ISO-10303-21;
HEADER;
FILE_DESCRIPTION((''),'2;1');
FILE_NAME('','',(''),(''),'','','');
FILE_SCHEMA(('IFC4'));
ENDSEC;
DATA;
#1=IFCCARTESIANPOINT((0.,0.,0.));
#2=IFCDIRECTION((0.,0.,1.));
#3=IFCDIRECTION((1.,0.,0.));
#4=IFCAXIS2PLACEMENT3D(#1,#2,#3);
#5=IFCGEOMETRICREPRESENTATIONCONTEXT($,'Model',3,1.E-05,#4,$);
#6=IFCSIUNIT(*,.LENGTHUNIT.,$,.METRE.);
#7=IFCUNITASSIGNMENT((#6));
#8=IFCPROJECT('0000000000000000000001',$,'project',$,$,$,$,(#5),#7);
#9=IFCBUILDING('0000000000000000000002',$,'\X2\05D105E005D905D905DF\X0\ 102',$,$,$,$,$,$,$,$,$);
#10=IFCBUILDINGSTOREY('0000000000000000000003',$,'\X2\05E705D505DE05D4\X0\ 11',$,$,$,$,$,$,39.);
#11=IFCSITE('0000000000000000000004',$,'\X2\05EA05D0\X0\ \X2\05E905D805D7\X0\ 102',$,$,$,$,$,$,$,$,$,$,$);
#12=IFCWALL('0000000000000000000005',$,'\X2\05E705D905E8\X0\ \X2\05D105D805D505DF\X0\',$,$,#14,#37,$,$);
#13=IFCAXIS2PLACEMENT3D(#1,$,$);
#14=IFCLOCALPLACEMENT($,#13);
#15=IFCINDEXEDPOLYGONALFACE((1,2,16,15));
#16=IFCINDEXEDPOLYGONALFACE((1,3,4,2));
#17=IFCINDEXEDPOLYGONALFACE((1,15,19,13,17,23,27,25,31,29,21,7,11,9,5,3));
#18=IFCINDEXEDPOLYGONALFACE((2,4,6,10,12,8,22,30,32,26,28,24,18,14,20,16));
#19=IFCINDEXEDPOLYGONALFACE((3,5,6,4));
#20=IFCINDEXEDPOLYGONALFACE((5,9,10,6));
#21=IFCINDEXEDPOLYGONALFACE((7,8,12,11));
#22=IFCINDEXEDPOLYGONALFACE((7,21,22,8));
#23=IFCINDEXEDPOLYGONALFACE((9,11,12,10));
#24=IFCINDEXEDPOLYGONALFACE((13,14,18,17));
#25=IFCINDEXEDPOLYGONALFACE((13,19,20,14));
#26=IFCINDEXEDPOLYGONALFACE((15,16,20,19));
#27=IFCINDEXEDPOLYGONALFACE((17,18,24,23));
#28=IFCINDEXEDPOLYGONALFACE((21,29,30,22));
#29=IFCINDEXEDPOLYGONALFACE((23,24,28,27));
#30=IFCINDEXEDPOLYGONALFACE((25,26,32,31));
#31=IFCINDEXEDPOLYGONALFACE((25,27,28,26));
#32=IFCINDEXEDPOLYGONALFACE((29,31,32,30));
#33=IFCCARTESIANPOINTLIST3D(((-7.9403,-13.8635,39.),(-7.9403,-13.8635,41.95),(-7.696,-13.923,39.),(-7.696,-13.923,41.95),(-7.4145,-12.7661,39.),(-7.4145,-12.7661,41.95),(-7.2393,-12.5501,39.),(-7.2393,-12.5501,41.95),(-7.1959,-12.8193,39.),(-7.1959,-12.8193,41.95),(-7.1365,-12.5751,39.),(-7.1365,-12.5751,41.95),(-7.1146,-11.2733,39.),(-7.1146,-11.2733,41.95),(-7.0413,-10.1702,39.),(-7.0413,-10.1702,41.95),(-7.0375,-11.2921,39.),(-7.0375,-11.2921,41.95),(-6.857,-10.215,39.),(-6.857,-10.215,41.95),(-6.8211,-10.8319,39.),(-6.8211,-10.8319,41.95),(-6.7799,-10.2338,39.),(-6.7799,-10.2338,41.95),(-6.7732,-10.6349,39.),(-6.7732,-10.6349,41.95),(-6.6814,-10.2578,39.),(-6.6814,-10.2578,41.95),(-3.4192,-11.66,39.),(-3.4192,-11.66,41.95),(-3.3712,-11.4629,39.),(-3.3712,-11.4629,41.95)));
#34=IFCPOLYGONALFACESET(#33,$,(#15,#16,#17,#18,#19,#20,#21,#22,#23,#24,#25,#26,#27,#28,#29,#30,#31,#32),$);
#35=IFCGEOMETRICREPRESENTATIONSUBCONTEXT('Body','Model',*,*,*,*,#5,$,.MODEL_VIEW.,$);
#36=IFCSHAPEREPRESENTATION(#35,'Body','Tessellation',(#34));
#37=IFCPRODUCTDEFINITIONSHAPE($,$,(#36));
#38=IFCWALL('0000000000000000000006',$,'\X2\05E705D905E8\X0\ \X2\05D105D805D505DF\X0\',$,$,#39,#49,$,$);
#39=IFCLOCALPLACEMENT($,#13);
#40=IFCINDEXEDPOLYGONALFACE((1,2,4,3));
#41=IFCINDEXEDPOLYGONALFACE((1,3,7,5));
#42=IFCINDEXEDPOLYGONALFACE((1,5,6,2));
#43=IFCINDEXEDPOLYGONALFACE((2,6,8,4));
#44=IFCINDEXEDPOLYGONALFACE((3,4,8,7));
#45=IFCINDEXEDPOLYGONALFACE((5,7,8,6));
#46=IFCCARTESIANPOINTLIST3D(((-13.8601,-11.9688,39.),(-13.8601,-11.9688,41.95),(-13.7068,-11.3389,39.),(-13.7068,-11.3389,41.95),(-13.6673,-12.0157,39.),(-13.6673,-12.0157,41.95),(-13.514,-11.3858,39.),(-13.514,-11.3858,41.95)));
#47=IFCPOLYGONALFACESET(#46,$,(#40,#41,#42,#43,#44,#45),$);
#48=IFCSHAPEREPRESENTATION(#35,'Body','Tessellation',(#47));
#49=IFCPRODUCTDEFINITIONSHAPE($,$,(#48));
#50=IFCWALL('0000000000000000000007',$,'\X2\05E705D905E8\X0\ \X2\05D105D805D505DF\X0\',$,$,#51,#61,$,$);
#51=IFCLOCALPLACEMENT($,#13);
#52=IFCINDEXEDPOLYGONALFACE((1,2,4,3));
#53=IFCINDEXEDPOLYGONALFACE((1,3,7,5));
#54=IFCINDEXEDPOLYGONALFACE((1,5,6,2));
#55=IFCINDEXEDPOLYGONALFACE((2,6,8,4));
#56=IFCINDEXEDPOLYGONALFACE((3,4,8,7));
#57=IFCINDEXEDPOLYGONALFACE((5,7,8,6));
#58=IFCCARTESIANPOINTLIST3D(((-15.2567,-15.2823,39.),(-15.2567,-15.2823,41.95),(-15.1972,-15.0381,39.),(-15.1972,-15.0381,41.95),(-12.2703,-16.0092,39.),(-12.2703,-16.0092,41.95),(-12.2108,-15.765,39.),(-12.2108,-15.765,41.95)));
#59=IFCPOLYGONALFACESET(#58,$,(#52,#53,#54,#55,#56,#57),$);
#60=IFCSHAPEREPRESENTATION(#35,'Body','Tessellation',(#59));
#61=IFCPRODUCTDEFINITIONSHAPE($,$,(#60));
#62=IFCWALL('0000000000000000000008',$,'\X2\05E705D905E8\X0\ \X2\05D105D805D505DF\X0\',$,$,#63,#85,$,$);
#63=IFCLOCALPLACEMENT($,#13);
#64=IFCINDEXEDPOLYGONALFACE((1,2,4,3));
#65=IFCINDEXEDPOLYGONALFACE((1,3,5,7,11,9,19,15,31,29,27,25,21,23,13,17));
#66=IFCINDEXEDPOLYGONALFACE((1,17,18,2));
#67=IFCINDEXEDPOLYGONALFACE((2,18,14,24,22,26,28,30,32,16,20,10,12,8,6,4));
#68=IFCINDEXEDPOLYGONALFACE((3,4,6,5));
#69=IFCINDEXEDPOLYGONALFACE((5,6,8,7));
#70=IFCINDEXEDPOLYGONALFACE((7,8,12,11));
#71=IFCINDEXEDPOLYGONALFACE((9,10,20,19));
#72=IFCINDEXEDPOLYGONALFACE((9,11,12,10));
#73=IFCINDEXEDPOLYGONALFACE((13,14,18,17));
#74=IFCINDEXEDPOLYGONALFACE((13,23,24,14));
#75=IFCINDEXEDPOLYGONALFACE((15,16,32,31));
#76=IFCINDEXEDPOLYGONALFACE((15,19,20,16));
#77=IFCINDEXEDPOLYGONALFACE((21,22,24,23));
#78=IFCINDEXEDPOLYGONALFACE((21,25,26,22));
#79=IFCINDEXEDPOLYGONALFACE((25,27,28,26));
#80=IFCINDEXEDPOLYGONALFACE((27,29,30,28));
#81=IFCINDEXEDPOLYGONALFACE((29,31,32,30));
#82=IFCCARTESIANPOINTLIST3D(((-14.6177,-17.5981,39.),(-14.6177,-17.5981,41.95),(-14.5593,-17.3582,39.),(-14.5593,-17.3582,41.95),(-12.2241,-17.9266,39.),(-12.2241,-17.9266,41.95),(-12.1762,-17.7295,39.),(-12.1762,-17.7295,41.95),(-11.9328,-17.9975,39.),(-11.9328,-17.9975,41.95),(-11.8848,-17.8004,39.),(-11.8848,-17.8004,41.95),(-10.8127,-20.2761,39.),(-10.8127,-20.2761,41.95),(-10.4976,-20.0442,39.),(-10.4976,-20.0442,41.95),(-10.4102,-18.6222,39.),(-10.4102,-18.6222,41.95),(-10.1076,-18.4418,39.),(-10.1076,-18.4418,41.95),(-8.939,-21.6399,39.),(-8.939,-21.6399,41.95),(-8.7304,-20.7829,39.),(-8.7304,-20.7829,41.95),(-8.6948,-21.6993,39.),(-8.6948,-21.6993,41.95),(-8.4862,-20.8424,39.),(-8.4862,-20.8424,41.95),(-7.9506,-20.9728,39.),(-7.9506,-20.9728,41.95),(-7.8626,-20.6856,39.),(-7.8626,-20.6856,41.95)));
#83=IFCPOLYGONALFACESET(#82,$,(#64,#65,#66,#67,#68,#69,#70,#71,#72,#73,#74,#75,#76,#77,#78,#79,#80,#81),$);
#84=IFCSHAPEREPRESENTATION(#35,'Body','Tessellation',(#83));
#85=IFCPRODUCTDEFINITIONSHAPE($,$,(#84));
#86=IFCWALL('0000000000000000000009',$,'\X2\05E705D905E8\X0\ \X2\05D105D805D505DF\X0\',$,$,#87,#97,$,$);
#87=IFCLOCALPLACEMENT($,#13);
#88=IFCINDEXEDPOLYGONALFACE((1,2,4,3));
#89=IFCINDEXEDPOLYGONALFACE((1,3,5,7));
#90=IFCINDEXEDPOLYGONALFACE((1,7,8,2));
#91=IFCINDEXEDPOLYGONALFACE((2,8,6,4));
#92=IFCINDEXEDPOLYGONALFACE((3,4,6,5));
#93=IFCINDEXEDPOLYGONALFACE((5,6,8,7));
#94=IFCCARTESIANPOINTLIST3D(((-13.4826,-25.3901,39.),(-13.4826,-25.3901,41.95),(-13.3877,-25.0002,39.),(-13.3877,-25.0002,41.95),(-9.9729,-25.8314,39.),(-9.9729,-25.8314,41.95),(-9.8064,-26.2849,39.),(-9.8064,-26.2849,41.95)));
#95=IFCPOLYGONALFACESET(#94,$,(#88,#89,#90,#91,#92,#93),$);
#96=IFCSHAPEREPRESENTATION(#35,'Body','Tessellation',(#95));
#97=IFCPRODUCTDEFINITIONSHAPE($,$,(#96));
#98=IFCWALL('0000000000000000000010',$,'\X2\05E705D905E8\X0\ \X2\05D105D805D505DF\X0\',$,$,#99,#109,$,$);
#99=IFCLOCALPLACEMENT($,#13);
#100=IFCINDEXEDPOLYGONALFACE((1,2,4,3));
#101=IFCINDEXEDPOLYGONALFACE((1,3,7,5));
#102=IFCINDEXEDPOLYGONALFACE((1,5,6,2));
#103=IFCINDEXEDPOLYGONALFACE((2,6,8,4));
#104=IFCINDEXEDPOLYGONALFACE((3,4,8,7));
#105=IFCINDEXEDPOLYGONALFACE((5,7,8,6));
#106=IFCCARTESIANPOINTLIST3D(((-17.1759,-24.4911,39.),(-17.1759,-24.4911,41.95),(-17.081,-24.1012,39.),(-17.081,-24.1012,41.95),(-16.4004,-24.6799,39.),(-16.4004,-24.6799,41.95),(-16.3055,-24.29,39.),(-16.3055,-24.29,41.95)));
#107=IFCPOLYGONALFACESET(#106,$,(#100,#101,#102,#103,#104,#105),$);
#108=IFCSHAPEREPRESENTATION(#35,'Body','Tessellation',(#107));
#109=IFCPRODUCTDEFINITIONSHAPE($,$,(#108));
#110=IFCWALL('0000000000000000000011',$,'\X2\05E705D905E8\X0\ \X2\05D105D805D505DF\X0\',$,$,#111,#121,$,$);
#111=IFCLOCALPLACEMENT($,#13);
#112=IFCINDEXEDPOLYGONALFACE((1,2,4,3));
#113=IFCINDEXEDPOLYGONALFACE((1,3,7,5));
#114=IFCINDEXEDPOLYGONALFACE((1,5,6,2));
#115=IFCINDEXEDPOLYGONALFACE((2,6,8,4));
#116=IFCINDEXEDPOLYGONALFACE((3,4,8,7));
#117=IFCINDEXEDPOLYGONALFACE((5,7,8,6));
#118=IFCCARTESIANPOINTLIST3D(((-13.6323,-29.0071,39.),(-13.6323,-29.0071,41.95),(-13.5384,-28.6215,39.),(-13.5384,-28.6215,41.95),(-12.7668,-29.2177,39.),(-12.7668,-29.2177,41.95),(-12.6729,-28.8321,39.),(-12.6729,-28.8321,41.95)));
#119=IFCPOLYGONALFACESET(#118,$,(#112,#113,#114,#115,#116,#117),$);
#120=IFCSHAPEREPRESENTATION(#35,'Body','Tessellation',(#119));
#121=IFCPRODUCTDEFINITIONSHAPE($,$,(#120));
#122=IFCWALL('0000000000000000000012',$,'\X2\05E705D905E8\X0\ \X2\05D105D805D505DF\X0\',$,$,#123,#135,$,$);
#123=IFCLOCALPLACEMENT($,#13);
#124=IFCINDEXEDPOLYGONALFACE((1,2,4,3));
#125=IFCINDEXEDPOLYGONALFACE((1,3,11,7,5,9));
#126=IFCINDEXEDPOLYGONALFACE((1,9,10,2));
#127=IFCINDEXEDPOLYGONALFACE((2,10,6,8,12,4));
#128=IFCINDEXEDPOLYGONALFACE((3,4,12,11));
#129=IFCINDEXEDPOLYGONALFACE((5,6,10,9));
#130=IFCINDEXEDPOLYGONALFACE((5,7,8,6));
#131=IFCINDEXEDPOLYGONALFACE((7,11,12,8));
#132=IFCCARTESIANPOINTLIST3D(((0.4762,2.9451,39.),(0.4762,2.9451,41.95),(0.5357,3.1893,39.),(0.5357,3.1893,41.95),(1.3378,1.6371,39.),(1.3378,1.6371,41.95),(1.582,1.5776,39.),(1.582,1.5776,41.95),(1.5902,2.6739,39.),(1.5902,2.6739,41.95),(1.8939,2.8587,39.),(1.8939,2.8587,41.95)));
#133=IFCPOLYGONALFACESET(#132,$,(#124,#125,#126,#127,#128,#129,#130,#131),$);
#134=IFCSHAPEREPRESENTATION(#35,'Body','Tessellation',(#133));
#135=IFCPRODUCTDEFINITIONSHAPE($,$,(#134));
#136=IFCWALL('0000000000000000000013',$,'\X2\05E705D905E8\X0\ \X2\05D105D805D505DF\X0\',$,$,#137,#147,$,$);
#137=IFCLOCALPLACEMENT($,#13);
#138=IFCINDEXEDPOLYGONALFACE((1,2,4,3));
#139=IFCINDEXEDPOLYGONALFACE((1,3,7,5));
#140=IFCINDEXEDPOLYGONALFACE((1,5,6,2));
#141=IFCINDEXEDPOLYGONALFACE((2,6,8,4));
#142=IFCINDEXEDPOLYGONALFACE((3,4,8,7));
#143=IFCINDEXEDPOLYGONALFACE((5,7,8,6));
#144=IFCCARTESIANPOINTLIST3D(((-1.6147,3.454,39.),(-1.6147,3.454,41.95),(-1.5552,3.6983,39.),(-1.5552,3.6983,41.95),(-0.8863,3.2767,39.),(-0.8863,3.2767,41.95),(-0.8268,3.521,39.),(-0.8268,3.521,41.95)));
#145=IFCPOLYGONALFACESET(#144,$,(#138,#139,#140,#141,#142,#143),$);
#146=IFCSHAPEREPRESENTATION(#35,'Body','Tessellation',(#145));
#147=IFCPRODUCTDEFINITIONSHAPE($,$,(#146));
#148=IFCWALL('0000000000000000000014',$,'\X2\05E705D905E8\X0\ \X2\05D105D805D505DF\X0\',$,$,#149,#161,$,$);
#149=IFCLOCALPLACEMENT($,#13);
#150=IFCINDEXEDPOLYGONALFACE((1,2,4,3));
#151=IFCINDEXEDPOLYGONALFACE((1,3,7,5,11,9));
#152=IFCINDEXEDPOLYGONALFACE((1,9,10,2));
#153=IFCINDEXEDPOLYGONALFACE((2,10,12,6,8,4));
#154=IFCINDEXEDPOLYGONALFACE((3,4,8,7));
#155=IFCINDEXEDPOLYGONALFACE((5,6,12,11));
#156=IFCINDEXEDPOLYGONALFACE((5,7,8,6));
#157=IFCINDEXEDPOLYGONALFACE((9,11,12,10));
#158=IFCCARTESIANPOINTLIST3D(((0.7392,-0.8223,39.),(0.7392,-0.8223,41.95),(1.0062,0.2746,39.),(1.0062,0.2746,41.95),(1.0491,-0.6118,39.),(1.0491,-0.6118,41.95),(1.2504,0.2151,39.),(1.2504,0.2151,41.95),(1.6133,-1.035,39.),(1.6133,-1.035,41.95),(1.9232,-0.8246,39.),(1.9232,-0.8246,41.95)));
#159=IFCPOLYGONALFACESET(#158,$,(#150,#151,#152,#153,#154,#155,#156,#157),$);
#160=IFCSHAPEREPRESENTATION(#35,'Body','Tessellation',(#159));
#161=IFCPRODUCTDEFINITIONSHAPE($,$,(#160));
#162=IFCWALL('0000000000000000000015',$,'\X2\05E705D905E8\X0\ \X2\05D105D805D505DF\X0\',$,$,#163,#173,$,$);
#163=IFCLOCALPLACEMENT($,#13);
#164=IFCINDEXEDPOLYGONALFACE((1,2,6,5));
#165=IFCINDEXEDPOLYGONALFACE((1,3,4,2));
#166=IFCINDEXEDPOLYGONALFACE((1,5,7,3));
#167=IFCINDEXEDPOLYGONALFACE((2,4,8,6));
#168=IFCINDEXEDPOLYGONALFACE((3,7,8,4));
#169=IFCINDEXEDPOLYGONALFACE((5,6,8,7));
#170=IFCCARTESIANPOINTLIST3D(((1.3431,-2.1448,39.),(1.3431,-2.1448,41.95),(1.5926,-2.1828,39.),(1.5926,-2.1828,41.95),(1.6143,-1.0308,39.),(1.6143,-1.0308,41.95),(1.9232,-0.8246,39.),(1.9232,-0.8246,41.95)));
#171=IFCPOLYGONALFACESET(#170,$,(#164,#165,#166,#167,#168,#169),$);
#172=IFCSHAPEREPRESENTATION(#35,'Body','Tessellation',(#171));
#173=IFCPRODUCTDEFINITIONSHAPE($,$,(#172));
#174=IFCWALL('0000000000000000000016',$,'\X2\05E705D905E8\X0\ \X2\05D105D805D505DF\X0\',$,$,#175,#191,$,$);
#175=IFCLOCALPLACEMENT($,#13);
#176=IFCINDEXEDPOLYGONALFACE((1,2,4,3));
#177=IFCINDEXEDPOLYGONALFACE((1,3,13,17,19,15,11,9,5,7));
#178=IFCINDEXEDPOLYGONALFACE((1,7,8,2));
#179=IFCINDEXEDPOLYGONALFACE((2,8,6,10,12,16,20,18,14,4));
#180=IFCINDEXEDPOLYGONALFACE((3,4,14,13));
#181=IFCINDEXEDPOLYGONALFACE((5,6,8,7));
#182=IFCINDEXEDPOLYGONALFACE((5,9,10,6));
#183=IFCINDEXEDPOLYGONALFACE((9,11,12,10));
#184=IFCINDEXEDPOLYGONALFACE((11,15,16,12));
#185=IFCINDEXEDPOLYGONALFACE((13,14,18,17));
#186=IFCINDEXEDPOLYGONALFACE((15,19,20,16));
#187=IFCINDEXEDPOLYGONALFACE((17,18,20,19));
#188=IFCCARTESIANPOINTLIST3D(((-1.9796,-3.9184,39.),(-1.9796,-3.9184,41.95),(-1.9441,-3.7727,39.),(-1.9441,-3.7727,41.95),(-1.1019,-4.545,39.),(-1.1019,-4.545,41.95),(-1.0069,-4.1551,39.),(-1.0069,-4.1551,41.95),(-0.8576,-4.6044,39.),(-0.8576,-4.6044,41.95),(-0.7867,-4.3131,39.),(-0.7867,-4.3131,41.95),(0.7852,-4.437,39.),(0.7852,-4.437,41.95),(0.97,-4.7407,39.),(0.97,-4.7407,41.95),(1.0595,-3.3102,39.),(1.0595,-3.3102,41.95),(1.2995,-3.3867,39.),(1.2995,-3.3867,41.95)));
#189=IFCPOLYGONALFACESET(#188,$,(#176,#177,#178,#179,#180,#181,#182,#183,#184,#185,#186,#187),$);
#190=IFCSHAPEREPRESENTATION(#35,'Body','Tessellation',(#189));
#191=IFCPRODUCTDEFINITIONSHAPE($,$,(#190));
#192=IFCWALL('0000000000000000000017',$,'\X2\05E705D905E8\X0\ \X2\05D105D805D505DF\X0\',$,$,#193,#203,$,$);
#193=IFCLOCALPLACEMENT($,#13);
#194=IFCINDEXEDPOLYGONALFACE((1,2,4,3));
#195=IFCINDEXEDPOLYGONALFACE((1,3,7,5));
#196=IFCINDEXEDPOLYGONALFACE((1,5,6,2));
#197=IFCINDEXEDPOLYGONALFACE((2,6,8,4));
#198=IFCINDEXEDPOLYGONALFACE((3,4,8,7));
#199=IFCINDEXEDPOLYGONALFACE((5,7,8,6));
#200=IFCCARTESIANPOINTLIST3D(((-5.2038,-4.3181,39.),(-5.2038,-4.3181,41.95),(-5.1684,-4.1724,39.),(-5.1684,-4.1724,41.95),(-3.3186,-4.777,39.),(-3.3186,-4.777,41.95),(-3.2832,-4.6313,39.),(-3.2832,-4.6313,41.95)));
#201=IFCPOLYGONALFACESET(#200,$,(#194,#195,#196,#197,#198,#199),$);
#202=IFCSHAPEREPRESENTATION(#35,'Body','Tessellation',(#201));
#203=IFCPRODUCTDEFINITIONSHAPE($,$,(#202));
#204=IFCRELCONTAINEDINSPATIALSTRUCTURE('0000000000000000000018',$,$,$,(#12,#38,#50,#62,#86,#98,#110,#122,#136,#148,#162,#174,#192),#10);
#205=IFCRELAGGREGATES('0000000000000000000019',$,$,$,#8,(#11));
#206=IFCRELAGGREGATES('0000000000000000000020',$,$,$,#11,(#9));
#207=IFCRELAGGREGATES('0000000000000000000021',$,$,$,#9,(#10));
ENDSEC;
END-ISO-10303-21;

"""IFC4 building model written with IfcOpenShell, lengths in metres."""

from ifc_helpers import new_model, si_unit, frame, origin_with_axes, context, subcontext, project, spatial, polyline, outline, extrude, element, save


model = new_model("IFC4")

# Units and contexts
model_context = context("Model", 3, precision=1e-05, world=origin_with_axes())
body_context = subcontext(model_context, "Body", "Model", "MODEL_VIEW")
ifc_project = project(units=[si_unit("LENGTHUNIT", "METRE")], contexts=[model_context])

# Site, building, storey
site = spatial("IfcSite", under=ifc_project, Name="תא שטח 102")
building = spatial("IfcBuilding", under=site, Name="בניין 102")
storey = spatial("IfcBuildingStorey", under=building, Name="קומה 11", Elevation=39.0)

# Walls
element("IfcWall", 1, inside=storey, Name="קיר בטון", context=body_context, shape_type="SweptSolid", body=[
    extrude(outline(polyline([(-7.0413, -10.1702), (-7.9403, -13.8635), (-7.696, -13.923), (-7.4145, -12.7661), (-7.1959, -12.8193), (-7.1365, -12.5751), (-7.2393, -12.5501), (-6.8211, -10.8319), (-3.4192, -11.66), (-3.3712, -11.4629), (-6.7732, -10.6349), (-6.6814, -10.2578), (-6.7799, -10.2338), (-7.0375, -11.2921), (-7.1146, -11.2733), (-6.857, -10.215), (-7.0413, -10.1702)])), frame((0.0, 0.0, 39.0)), (0.0, 0.0, 1.0), 2.95),
])
element("IfcWall", 2, inside=storey, Name="קיר בטון", context=body_context, shape_type="SweptSolid", body=[
    extrude(outline(polyline([(-13.6673, -12.0157), (-13.514, -11.3858), (-13.7068, -11.3389), (-13.8601, -11.9688), (-13.6673, -12.0157)])), frame((0.0, 0.0, 39.0)), (0.0, 0.0, 1.0), 2.95),
])
element("IfcWall", 3, inside=storey, Name="קיר בטון", context=body_context, shape_type="SweptSolid", body=[
    extrude(outline(polyline([(-15.1972, -15.0381), (-15.2567, -15.2823), (-12.2703, -16.0092), (-12.2108, -15.765), (-15.1972, -15.0381)])), frame((0.0, 0.0, 39.0)), (0.0, 0.0, 1.0), 2.95),
])
element("IfcWall", 4, inside=storey, Name="קיר בטון", context=body_context, shape_type="SweptSolid", body=[
    extrude(outline(polyline([(-12.2241, -17.9266), (-14.5593, -17.3582), (-14.6177, -17.5981), (-10.4102, -18.6222), (-10.8127, -20.2761), (-8.7304, -20.7829), (-8.939, -21.6399), (-8.6948, -21.6993), (-8.4862, -20.8424), (-7.9506, -20.9728), (-7.8626, -20.6856), (-10.4976, -20.0442), (-10.1076, -18.4418), (-11.9328, -17.9975), (-11.8848, -17.8004), (-12.1762, -17.7295), (-12.2241, -17.9266)])), frame((0.0, 0.0, 39.0)), (0.0, 0.0, 1.0), 2.95),
])
element("IfcWall", 5, inside=storey, Name="קיר בטון", context=body_context, shape_type="SweptSolid", body=[
    extrude(outline(polyline([(-9.9729, -25.8314), (-13.3877, -25.0002), (-13.4826, -25.3901), (-9.8064, -26.2849), (-9.9729, -25.8314)])), frame((0.0, 0.0, 39.0)), (0.0, 0.0, 1.0), 2.95),
])
element("IfcWall", 6, inside=storey, Name="קיר בטון", context=body_context, shape_type="SweptSolid", body=[
    extrude(outline(polyline([(-16.4004, -24.6799), (-16.3055, -24.29), (-17.081, -24.1012), (-17.1759, -24.4911), (-16.4004, -24.6799)])), frame((0.0, 0.0, 39.0)), (0.0, 0.0, 1.0), 2.95),
])
element("IfcWall", 7, inside=storey, Name="קיר בטון", context=body_context, shape_type="SweptSolid", body=[
    extrude(outline(polyline([(-12.7668, -29.2177), (-12.6729, -28.8321), (-13.5384, -28.6215), (-13.6323, -29.0071), (-12.7668, -29.2177)])), frame((0.0, 0.0, 39.0)), (0.0, 0.0, 1.0), 2.95),
])
element("IfcWall", 8, inside=storey, Name="קיר בטון", context=body_context, shape_type="SweptSolid", body=[
    extrude(outline(polyline([(1.3378, 1.6371), (1.582, 1.5776), (1.8939, 2.8587), (0.5357, 3.1893), (0.4762, 2.9451), (1.5902, 2.6739), (1.3378, 1.6371)])), frame((0.0, 0.0, 39.0)), (0.0, 0.0, 1.0), 2.95),
])
element("IfcWall", 9, inside=storey, Name="קיר בטון", context=body_context, shape_type="SweptSolid", body=[
    extrude(outline(polyline([(-1.5552, 3.6983), (-1.6147, 3.454), (-0.8863, 3.2767), (-0.8268, 3.521), (-1.5552, 3.6983)])), frame((0.0, 0.0, 39.0)), (0.0, 0.0, 1.0), 2.95),
])
element("IfcWall", 10, inside=storey, Name="קיר בטון", context=body_context, shape_type="SweptSolid", body=[
    extrude(outline(polyline([(1.9232, -0.8246), (1.0491, -0.6118), (1.2504, 0.2151), (1.0062, 0.2746), (0.7392, -0.8223), (1.6133, -1.035), (1.9232, -0.8246)])), frame((0.0, 0.0, 39.0)), (0.0, 0.0, 1.0), 2.95),
])
element("IfcWall", 11, inside=storey, Name="קיר בטון", context=body_context, shape_type="SweptSolid", body=[
    extrude(outline(polyline([(1.3431, -2.1448), (1.5926, -2.1828), (1.9232, -0.8246), (1.6143, -1.0308), (1.3431, -2.1448)])), frame((0.0, 0.0, 39.0)), (0.0, 0.0, 1.0), 2.95),
])
element("IfcWall", 12, inside=storey, Name="קיר בטון", context=body_context, shape_type="SweptSolid", body=[
    extrude(outline(polyline([(-1.9441, -3.7727), (-1.9796, -3.9184), (-1.0069, -4.1551), (-1.1019, -4.545), (-0.8576, -4.6044), (-0.7867, -4.3131), (0.97, -4.7407), (1.2995, -3.3867), (1.0595, -3.3102), (0.7852, -4.437), (-1.9441, -3.7727)])), frame((0.0, 0.0, 39.0)), (0.0, 0.0, 1.0), 2.95),
])
element("IfcWall", 13, inside=storey, Name="קיר בטון", context=body_context, shape_type="SweptSolid", body=[
    extrude(outline(polyline([(-3.2832, -4.6313), (-5.1684, -4.1724), (-5.2038, -4.3181), (-3.3186, -4.777), (-3.2832, -4.6313)])), frame((0.0, 0.0, 39.0)), (0.0, 0.0, 1.0), 2.95),
])

save(model, "model.ifc")
